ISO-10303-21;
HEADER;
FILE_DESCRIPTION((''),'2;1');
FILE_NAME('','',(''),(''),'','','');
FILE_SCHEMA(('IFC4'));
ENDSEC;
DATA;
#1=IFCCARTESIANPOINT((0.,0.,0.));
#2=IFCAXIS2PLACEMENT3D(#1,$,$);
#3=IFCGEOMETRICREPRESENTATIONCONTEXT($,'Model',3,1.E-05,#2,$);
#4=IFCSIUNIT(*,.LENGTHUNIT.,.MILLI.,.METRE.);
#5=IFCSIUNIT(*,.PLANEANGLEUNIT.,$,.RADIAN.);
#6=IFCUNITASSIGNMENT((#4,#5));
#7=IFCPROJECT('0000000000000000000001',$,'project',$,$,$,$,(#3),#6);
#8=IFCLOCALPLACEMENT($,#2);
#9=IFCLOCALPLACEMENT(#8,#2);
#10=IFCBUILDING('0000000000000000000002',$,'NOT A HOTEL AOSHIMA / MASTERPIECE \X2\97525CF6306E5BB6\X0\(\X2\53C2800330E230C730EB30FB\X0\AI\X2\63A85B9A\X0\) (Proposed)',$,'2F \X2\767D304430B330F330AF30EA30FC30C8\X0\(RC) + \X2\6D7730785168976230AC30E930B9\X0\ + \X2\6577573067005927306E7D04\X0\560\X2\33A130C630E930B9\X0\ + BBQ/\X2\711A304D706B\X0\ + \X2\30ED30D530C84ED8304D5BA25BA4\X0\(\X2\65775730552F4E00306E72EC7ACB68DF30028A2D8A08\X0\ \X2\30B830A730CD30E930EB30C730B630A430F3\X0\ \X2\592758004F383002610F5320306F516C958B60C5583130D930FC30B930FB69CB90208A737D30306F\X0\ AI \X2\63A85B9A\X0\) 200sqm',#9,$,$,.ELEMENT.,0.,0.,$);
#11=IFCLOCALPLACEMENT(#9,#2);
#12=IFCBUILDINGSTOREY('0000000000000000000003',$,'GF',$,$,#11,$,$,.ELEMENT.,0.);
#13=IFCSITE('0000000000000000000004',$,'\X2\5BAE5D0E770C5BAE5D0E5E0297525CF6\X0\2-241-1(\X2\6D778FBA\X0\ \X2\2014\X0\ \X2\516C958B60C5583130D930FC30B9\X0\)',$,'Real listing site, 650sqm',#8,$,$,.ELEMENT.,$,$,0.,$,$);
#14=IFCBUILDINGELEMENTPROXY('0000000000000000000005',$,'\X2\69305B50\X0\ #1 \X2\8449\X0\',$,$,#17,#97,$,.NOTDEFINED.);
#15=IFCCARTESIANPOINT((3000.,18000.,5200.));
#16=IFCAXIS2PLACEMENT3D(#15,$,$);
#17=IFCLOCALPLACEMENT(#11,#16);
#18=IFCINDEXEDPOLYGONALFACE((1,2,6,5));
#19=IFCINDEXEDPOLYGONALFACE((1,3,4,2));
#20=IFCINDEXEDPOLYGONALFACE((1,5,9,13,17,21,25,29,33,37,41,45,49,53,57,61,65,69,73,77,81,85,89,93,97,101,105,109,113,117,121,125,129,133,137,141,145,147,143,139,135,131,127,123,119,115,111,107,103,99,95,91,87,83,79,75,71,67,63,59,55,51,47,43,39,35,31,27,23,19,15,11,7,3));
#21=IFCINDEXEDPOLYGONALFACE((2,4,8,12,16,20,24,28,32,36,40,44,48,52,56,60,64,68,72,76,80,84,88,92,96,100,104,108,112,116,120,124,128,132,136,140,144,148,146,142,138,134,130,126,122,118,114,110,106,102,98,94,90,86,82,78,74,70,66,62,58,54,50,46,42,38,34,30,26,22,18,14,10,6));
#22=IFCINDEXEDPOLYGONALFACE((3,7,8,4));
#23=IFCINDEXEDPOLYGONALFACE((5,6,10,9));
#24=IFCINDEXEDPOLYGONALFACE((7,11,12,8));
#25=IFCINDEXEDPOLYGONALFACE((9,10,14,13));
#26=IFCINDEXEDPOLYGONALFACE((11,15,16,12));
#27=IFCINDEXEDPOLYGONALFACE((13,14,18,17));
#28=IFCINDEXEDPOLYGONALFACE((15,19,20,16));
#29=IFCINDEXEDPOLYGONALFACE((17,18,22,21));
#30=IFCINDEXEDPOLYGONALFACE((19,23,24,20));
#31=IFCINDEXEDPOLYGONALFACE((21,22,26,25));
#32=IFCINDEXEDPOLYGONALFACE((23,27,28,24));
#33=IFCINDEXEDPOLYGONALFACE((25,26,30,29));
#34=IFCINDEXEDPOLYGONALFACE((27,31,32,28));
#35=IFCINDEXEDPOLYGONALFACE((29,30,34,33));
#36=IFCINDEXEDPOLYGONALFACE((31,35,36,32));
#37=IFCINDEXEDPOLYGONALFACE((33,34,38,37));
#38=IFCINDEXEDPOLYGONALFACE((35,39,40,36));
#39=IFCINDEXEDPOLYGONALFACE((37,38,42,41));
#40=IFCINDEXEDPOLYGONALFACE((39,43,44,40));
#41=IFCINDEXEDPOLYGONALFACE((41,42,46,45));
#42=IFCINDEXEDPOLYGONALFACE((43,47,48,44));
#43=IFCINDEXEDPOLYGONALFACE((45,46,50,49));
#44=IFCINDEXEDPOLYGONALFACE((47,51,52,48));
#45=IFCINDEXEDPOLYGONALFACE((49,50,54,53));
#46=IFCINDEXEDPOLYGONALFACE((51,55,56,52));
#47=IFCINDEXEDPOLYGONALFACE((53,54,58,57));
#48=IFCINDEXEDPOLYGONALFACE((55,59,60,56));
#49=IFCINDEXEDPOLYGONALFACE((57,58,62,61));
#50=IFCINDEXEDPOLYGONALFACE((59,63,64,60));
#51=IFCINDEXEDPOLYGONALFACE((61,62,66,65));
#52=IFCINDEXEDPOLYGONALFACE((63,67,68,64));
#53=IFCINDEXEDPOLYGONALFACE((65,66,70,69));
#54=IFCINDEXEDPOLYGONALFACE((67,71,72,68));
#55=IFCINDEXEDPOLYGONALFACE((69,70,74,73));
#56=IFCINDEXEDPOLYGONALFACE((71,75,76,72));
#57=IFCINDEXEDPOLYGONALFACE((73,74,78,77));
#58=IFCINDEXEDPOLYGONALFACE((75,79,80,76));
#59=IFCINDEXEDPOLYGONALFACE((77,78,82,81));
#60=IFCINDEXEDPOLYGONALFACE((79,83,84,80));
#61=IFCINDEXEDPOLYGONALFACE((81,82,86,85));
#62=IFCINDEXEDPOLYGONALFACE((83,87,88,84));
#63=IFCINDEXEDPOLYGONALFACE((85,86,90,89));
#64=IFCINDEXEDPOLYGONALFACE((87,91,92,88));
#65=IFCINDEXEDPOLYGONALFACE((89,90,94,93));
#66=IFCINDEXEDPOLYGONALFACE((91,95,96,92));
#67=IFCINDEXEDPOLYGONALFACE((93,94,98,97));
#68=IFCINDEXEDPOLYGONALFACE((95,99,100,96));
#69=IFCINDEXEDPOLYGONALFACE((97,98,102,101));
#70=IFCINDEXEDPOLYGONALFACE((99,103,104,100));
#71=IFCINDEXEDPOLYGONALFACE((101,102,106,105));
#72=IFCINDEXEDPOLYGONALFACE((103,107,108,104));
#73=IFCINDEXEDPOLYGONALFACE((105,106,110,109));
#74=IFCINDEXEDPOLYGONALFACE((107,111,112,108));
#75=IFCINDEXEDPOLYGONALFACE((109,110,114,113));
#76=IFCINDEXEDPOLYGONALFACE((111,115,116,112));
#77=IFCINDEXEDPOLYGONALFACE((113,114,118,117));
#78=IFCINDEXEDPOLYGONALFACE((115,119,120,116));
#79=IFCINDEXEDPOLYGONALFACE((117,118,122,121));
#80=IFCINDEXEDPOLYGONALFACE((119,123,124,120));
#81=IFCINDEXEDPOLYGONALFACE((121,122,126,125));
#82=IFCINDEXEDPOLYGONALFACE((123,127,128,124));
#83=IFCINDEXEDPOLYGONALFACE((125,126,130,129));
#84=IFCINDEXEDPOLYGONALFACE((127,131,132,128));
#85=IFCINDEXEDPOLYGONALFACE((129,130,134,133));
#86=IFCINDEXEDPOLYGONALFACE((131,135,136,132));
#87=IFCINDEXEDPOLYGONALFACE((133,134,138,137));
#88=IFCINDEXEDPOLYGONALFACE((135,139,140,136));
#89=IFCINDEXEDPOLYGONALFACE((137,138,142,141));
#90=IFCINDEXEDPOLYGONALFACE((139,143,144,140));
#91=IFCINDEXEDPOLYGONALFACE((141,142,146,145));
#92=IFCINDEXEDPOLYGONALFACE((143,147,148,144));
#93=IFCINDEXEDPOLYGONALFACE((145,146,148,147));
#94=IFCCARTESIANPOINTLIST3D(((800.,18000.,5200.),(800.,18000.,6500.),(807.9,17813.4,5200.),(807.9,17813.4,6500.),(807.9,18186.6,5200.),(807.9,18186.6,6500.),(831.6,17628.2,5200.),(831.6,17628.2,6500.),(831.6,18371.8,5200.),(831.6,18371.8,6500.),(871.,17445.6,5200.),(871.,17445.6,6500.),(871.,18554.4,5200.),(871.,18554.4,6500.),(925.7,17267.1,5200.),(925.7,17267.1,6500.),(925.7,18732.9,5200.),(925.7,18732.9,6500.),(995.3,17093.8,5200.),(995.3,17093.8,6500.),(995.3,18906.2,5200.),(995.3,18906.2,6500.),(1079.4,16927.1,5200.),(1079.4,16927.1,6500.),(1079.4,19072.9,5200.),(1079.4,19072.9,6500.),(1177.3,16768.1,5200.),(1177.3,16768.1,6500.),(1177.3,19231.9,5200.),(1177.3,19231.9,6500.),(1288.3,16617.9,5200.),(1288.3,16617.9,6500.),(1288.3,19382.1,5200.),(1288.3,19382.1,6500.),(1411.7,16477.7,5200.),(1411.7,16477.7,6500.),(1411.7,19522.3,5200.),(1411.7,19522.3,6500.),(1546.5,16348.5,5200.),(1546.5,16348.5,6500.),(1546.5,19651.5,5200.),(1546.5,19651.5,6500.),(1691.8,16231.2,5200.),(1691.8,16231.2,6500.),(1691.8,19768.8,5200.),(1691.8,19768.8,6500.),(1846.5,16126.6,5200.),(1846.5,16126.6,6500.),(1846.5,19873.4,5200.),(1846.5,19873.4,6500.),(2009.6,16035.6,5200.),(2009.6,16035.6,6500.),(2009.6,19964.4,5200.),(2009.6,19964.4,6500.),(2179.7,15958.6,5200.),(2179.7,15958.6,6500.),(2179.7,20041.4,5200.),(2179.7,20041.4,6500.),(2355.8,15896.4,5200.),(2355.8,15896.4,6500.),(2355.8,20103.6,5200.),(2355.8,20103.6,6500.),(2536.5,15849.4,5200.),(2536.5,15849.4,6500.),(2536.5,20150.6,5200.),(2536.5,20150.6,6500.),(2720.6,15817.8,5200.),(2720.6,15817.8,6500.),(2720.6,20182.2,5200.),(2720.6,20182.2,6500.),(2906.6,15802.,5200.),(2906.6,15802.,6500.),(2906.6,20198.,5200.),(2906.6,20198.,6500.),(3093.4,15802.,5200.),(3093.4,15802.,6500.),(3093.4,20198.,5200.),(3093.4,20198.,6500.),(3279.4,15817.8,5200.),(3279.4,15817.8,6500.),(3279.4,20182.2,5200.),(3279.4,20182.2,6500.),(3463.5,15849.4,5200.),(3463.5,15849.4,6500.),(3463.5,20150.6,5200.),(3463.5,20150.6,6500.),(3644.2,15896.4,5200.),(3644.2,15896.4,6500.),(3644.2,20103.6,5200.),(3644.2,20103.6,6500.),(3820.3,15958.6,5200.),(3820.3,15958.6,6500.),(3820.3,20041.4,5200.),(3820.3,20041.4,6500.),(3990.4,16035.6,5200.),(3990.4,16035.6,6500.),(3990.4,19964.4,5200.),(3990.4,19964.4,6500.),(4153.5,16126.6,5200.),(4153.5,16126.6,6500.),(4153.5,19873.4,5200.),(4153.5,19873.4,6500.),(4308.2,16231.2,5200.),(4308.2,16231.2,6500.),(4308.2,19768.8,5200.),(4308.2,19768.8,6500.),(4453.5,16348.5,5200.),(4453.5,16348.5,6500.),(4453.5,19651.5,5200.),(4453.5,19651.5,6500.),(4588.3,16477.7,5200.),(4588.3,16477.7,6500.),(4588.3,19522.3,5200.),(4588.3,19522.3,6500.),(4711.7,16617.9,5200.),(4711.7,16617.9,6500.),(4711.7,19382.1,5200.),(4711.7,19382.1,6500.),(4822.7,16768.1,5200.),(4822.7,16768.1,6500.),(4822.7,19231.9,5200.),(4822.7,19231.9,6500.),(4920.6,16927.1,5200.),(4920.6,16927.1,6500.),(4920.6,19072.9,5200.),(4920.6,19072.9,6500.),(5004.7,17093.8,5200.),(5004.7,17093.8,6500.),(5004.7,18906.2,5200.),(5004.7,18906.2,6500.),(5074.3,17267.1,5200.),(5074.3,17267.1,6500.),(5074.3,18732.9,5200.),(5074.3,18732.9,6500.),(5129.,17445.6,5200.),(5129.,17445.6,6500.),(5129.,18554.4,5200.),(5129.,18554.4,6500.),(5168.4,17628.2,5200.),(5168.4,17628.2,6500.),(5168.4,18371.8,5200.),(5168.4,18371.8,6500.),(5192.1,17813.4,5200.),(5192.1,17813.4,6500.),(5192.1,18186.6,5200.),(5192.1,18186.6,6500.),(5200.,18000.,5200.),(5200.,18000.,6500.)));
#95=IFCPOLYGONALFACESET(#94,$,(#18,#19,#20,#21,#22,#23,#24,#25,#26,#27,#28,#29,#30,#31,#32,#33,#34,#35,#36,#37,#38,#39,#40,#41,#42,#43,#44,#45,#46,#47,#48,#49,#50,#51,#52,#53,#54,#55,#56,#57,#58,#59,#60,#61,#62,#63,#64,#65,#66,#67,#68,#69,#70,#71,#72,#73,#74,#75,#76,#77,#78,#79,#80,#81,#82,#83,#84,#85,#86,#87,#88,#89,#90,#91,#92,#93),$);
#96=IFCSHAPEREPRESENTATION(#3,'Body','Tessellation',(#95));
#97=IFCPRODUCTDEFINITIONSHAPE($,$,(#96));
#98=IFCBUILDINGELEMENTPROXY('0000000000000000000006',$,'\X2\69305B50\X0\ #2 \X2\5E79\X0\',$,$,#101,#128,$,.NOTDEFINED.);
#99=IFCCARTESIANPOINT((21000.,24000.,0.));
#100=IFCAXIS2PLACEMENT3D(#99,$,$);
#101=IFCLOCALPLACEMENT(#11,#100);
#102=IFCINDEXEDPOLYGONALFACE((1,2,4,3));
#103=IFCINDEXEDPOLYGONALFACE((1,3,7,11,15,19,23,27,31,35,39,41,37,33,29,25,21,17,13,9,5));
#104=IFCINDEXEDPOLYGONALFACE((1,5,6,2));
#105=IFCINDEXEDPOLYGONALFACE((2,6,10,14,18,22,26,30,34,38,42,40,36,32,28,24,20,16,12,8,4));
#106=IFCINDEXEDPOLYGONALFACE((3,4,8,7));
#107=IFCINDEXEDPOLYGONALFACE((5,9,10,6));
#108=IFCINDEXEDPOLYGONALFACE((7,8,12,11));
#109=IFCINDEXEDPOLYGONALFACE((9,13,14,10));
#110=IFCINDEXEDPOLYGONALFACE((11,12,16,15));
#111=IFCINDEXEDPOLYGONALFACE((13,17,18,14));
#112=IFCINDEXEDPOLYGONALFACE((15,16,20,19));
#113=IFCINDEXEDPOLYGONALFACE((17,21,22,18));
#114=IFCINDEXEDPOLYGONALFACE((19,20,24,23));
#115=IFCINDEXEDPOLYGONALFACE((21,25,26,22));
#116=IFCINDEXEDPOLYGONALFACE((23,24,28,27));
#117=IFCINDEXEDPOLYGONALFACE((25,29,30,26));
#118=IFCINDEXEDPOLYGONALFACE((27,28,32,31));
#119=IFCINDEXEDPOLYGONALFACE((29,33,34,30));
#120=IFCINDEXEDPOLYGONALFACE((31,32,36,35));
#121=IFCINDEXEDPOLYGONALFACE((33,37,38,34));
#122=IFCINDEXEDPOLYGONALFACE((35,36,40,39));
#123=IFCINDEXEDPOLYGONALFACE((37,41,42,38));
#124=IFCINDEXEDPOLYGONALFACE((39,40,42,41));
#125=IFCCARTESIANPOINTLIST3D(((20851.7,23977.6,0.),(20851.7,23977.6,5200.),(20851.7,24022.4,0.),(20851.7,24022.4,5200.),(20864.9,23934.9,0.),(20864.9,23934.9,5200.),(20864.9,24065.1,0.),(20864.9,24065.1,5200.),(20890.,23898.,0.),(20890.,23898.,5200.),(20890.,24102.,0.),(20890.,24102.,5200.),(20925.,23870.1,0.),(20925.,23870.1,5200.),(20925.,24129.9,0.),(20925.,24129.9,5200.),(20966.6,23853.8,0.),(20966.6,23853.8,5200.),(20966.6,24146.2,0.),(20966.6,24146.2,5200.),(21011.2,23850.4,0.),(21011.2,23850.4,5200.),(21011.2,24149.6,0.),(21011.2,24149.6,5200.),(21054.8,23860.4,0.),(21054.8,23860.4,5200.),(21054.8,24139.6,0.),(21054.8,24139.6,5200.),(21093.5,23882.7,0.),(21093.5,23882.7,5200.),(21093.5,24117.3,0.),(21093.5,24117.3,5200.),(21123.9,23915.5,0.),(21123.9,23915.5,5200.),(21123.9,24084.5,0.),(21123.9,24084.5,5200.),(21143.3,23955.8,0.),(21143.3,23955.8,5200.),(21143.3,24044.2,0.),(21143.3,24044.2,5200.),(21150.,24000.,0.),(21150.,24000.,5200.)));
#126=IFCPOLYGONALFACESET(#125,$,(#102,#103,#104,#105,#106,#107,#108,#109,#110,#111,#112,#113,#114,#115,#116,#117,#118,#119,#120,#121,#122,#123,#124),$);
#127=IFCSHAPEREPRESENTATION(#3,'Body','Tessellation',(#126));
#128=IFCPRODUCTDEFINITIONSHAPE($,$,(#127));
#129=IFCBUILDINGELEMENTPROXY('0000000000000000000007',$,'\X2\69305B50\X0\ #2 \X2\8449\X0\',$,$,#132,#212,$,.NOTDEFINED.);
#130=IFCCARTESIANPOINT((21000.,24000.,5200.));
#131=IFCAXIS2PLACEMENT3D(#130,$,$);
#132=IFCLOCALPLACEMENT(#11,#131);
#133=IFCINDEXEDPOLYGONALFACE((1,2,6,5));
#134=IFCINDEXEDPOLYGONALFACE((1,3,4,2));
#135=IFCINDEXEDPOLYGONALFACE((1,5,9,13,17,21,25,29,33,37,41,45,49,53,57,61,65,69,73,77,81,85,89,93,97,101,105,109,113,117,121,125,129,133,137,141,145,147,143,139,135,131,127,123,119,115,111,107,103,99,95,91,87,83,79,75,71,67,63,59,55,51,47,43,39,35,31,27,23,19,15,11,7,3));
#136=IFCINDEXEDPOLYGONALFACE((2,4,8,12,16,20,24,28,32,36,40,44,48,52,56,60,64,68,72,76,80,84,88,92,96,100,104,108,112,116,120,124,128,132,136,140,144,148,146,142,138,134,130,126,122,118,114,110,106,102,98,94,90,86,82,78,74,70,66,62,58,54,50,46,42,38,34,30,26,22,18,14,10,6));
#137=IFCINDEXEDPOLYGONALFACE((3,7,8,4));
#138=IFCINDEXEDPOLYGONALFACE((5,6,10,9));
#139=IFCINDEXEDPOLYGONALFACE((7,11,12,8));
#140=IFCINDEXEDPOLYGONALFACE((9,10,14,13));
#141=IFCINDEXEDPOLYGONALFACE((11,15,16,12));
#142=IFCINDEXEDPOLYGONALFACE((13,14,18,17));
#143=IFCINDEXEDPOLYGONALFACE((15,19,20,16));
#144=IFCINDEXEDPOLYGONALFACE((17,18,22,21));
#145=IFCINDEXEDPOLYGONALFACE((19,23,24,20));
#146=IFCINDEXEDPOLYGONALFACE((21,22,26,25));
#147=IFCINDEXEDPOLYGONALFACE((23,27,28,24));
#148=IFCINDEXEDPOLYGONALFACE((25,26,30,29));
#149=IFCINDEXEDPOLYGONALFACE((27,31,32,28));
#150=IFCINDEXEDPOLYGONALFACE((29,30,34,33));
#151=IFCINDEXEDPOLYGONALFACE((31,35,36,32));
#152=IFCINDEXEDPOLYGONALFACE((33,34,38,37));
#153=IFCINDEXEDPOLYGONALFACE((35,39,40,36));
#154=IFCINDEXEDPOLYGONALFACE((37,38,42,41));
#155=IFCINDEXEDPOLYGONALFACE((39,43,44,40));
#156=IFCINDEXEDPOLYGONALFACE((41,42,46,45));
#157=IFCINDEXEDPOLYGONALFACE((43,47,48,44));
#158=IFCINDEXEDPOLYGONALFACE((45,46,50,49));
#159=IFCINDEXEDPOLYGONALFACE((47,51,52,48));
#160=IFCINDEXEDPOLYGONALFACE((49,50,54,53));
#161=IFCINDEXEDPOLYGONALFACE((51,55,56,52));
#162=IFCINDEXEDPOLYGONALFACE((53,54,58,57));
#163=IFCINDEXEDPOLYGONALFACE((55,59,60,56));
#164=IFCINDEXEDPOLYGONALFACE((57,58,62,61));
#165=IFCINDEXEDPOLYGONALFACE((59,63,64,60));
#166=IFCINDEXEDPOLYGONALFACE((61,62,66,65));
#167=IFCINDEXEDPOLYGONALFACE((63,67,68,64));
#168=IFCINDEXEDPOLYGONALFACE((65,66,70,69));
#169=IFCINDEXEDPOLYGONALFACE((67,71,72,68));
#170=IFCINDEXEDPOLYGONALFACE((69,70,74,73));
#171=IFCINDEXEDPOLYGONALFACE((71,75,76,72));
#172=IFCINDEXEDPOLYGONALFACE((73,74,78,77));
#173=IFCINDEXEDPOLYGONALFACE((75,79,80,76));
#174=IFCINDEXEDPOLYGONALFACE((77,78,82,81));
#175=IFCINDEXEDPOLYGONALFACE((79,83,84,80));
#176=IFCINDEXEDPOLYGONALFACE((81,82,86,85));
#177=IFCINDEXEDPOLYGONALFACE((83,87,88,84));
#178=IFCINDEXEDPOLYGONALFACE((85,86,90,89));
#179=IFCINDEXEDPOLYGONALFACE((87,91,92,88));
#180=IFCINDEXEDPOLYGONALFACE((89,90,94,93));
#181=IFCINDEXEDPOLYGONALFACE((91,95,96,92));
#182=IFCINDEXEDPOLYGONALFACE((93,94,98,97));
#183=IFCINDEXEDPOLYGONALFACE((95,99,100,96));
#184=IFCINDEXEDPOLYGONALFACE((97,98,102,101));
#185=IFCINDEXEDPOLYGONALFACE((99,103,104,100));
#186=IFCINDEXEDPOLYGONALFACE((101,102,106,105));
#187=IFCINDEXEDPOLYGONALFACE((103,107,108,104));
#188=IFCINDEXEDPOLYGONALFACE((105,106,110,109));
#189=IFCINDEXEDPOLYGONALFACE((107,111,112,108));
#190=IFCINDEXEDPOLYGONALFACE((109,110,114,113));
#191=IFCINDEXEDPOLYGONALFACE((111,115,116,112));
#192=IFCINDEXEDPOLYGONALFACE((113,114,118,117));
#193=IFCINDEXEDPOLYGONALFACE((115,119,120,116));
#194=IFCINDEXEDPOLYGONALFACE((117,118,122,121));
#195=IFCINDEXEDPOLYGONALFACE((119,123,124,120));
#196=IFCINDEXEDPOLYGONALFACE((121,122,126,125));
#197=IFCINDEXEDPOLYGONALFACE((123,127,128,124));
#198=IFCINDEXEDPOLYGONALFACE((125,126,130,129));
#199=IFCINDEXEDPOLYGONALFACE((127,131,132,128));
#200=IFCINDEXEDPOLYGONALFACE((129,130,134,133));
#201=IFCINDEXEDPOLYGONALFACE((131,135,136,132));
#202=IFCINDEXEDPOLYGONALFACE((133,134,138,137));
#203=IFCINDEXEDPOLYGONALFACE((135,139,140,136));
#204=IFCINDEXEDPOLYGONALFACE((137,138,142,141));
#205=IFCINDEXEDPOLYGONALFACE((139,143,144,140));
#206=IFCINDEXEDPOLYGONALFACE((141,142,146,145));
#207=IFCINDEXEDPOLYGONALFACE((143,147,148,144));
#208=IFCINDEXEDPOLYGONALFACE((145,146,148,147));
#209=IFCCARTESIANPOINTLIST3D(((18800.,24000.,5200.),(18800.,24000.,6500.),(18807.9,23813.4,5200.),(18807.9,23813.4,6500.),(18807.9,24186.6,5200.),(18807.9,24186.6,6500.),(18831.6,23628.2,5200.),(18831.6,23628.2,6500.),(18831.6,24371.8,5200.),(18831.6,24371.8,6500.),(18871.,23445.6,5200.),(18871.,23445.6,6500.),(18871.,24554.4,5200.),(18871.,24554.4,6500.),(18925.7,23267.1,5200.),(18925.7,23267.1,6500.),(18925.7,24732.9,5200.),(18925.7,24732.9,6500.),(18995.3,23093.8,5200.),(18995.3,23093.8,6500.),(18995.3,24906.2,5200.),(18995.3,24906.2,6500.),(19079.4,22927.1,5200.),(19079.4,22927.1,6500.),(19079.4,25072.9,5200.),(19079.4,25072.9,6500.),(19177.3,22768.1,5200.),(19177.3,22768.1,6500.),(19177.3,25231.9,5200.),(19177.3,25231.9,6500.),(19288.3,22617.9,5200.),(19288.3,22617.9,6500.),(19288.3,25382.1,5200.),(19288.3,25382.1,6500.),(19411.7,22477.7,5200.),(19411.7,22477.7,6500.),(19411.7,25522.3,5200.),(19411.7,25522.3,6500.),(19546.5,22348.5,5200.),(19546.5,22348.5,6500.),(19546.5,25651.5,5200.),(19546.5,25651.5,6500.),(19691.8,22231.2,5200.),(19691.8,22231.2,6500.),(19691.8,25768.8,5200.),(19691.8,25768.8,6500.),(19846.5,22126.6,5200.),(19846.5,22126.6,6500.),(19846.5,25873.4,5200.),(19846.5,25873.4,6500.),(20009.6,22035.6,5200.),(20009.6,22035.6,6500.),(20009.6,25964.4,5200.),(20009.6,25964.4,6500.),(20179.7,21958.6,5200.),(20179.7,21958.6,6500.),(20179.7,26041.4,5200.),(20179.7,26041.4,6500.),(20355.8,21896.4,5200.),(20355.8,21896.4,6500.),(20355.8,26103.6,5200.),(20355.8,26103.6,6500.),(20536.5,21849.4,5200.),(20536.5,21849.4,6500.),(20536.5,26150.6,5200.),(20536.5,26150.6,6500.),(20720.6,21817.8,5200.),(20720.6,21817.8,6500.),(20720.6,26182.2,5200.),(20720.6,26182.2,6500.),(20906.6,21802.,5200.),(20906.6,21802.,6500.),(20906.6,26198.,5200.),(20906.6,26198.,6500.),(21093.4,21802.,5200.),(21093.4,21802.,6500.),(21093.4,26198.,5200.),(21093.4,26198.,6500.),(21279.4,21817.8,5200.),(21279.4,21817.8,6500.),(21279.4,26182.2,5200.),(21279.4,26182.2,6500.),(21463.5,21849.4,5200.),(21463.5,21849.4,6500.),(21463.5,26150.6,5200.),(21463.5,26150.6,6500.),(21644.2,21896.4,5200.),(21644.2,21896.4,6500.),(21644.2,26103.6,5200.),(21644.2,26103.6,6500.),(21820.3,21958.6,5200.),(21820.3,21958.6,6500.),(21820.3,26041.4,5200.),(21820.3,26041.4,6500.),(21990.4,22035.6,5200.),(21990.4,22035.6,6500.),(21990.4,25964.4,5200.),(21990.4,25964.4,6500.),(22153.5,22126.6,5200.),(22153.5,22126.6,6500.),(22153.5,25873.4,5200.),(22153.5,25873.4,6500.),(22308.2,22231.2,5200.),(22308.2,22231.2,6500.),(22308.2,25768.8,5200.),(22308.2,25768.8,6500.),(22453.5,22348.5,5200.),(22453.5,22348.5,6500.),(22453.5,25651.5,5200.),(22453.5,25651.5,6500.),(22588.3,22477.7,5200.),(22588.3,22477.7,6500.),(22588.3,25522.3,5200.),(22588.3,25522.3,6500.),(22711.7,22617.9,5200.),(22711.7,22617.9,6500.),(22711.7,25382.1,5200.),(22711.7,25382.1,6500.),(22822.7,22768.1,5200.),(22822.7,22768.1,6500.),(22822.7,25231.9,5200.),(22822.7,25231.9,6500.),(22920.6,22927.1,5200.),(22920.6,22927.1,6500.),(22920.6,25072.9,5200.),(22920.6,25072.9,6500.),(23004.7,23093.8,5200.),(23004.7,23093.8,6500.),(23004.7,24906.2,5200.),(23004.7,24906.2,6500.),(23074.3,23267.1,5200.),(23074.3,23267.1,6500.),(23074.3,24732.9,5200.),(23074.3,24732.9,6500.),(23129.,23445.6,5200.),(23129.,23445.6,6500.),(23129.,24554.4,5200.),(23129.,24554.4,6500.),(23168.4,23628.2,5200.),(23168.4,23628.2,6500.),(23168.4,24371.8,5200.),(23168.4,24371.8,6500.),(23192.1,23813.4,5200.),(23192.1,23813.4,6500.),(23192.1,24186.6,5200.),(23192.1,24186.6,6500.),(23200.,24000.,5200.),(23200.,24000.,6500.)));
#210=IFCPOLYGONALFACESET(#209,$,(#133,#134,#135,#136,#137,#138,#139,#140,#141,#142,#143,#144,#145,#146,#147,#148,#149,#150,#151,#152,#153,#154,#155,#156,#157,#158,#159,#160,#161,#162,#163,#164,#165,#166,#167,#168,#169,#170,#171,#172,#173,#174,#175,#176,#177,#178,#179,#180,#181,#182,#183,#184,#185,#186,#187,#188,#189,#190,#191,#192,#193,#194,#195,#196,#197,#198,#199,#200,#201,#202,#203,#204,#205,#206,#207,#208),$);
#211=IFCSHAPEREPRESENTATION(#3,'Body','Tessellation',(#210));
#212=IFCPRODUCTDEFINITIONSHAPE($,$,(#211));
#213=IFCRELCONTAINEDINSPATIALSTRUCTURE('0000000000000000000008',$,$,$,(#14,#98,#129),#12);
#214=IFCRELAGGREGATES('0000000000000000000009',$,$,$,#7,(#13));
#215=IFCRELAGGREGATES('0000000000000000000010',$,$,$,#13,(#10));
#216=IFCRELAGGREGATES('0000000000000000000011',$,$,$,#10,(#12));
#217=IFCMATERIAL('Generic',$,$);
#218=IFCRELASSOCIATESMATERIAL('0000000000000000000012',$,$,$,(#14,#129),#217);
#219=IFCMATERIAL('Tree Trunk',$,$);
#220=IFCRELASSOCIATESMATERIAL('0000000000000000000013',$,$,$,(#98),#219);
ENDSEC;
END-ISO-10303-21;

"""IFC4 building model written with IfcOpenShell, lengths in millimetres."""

from ifc_helpers import new_model, si_unit, frame, origin, origin_2d, place, context, project, spatial, circle, extrude, material, element, save


model = new_model("IFC4")

# Units and contexts
model_context = context("Model", 3, precision=1e-05, world=origin())
ifc_project = project(units=[si_unit("LENGTHUNIT", "METRE", prefix="MILLI"), si_unit("PLANEANGLEUNIT", "RADIAN")], contexts=[model_context])

# Site, building, storey
site_placement = place(None, origin())
site = spatial("IfcSite", under=ifc_project, at=site_placement, Name="宮崎県宮崎市青島2-241-1(海辺 — 公開情報ベース)", ObjectType="Real listing site, 650sqm", CompositionType="ELEMENT", RefElevation=0.0)
building_placement = place(site_placement, origin())
building = spatial("IfcBuilding", under=site, at=building_placement, Name="NOT A HOTEL AOSHIMA / MASTERPIECE 青島の家(参考モデル・AI推定) (Proposed)", ObjectType="2F 白いコンクリート(RC) + 海へ全面ガラス + 敷地最大の約560㎡テラス + BBQ/焚き火 + ロフト付き客室(敷地唯一の独立棟。設計 ジェネラルデザイン 大堀伸。意匠は公開情報ベース・構造詳細は AI 推定) 200sqm", CompositionType="ELEMENT", ElevationOfRefHeight=0.0, ElevationOfTerrain=0.0)
storey_placement = place(building_placement, origin())
storey = spatial("IfcBuildingStorey", under=building, at=storey_placement, Name="GF", CompositionType="ELEMENT", Elevation=0.0)

# Shared definitions
ifc_material_1 = material(Name="Generic")

# Building element proxies
ifc_material_2 = material(Name="Tree Trunk")
proxy_1_placement = place(storey_placement, frame((3000.0, 18000.0, 5200.0)))
element("IfcBuildingElementProxy", 1, at=proxy_1_placement, inside=storey, material=ifc_material_1, Name="椰子 #1 葉", PredefinedType="NOTDEFINED", context=model_context, shape_type="SweptSolid", body=[
    extrude(circle(Radius=2200.0, at=origin_2d()), frame((3000.0, 18000.0, 5200.0)), (0.0, 0.0, 1.0), 1300.0),
])
proxy_2_placement = place(storey_placement, frame((21000.0, 24000.0, 0.0)))
element("IfcBuildingElementProxy", 2, at=proxy_2_placement, inside=storey, material=ifc_material_2, Name="椰子 #2 幹", PredefinedType="NOTDEFINED", context=model_context, shape_type="SweptSolid", body=[
    extrude(circle(Radius=150.0, at=origin_2d()), frame((21000.0, 24000.0, 0.0)), (0.0, 0.0, 1.0), 5200.0),
])
proxy_3_placement = place(storey_placement, frame((21000.0, 24000.0, 5200.0)))
element("IfcBuildingElementProxy", 3, at=proxy_3_placement, inside=storey, material=ifc_material_1, Name="椰子 #2 葉", PredefinedType="NOTDEFINED", context=model_context, shape_type="SweptSolid", body=[
    extrude(circle(Radius=2200.0, at=origin_2d()), frame((21000.0, 24000.0, 5200.0)), (0.0, 0.0, 1.0), 1300.0),
])

save(model, "model.ifc")
